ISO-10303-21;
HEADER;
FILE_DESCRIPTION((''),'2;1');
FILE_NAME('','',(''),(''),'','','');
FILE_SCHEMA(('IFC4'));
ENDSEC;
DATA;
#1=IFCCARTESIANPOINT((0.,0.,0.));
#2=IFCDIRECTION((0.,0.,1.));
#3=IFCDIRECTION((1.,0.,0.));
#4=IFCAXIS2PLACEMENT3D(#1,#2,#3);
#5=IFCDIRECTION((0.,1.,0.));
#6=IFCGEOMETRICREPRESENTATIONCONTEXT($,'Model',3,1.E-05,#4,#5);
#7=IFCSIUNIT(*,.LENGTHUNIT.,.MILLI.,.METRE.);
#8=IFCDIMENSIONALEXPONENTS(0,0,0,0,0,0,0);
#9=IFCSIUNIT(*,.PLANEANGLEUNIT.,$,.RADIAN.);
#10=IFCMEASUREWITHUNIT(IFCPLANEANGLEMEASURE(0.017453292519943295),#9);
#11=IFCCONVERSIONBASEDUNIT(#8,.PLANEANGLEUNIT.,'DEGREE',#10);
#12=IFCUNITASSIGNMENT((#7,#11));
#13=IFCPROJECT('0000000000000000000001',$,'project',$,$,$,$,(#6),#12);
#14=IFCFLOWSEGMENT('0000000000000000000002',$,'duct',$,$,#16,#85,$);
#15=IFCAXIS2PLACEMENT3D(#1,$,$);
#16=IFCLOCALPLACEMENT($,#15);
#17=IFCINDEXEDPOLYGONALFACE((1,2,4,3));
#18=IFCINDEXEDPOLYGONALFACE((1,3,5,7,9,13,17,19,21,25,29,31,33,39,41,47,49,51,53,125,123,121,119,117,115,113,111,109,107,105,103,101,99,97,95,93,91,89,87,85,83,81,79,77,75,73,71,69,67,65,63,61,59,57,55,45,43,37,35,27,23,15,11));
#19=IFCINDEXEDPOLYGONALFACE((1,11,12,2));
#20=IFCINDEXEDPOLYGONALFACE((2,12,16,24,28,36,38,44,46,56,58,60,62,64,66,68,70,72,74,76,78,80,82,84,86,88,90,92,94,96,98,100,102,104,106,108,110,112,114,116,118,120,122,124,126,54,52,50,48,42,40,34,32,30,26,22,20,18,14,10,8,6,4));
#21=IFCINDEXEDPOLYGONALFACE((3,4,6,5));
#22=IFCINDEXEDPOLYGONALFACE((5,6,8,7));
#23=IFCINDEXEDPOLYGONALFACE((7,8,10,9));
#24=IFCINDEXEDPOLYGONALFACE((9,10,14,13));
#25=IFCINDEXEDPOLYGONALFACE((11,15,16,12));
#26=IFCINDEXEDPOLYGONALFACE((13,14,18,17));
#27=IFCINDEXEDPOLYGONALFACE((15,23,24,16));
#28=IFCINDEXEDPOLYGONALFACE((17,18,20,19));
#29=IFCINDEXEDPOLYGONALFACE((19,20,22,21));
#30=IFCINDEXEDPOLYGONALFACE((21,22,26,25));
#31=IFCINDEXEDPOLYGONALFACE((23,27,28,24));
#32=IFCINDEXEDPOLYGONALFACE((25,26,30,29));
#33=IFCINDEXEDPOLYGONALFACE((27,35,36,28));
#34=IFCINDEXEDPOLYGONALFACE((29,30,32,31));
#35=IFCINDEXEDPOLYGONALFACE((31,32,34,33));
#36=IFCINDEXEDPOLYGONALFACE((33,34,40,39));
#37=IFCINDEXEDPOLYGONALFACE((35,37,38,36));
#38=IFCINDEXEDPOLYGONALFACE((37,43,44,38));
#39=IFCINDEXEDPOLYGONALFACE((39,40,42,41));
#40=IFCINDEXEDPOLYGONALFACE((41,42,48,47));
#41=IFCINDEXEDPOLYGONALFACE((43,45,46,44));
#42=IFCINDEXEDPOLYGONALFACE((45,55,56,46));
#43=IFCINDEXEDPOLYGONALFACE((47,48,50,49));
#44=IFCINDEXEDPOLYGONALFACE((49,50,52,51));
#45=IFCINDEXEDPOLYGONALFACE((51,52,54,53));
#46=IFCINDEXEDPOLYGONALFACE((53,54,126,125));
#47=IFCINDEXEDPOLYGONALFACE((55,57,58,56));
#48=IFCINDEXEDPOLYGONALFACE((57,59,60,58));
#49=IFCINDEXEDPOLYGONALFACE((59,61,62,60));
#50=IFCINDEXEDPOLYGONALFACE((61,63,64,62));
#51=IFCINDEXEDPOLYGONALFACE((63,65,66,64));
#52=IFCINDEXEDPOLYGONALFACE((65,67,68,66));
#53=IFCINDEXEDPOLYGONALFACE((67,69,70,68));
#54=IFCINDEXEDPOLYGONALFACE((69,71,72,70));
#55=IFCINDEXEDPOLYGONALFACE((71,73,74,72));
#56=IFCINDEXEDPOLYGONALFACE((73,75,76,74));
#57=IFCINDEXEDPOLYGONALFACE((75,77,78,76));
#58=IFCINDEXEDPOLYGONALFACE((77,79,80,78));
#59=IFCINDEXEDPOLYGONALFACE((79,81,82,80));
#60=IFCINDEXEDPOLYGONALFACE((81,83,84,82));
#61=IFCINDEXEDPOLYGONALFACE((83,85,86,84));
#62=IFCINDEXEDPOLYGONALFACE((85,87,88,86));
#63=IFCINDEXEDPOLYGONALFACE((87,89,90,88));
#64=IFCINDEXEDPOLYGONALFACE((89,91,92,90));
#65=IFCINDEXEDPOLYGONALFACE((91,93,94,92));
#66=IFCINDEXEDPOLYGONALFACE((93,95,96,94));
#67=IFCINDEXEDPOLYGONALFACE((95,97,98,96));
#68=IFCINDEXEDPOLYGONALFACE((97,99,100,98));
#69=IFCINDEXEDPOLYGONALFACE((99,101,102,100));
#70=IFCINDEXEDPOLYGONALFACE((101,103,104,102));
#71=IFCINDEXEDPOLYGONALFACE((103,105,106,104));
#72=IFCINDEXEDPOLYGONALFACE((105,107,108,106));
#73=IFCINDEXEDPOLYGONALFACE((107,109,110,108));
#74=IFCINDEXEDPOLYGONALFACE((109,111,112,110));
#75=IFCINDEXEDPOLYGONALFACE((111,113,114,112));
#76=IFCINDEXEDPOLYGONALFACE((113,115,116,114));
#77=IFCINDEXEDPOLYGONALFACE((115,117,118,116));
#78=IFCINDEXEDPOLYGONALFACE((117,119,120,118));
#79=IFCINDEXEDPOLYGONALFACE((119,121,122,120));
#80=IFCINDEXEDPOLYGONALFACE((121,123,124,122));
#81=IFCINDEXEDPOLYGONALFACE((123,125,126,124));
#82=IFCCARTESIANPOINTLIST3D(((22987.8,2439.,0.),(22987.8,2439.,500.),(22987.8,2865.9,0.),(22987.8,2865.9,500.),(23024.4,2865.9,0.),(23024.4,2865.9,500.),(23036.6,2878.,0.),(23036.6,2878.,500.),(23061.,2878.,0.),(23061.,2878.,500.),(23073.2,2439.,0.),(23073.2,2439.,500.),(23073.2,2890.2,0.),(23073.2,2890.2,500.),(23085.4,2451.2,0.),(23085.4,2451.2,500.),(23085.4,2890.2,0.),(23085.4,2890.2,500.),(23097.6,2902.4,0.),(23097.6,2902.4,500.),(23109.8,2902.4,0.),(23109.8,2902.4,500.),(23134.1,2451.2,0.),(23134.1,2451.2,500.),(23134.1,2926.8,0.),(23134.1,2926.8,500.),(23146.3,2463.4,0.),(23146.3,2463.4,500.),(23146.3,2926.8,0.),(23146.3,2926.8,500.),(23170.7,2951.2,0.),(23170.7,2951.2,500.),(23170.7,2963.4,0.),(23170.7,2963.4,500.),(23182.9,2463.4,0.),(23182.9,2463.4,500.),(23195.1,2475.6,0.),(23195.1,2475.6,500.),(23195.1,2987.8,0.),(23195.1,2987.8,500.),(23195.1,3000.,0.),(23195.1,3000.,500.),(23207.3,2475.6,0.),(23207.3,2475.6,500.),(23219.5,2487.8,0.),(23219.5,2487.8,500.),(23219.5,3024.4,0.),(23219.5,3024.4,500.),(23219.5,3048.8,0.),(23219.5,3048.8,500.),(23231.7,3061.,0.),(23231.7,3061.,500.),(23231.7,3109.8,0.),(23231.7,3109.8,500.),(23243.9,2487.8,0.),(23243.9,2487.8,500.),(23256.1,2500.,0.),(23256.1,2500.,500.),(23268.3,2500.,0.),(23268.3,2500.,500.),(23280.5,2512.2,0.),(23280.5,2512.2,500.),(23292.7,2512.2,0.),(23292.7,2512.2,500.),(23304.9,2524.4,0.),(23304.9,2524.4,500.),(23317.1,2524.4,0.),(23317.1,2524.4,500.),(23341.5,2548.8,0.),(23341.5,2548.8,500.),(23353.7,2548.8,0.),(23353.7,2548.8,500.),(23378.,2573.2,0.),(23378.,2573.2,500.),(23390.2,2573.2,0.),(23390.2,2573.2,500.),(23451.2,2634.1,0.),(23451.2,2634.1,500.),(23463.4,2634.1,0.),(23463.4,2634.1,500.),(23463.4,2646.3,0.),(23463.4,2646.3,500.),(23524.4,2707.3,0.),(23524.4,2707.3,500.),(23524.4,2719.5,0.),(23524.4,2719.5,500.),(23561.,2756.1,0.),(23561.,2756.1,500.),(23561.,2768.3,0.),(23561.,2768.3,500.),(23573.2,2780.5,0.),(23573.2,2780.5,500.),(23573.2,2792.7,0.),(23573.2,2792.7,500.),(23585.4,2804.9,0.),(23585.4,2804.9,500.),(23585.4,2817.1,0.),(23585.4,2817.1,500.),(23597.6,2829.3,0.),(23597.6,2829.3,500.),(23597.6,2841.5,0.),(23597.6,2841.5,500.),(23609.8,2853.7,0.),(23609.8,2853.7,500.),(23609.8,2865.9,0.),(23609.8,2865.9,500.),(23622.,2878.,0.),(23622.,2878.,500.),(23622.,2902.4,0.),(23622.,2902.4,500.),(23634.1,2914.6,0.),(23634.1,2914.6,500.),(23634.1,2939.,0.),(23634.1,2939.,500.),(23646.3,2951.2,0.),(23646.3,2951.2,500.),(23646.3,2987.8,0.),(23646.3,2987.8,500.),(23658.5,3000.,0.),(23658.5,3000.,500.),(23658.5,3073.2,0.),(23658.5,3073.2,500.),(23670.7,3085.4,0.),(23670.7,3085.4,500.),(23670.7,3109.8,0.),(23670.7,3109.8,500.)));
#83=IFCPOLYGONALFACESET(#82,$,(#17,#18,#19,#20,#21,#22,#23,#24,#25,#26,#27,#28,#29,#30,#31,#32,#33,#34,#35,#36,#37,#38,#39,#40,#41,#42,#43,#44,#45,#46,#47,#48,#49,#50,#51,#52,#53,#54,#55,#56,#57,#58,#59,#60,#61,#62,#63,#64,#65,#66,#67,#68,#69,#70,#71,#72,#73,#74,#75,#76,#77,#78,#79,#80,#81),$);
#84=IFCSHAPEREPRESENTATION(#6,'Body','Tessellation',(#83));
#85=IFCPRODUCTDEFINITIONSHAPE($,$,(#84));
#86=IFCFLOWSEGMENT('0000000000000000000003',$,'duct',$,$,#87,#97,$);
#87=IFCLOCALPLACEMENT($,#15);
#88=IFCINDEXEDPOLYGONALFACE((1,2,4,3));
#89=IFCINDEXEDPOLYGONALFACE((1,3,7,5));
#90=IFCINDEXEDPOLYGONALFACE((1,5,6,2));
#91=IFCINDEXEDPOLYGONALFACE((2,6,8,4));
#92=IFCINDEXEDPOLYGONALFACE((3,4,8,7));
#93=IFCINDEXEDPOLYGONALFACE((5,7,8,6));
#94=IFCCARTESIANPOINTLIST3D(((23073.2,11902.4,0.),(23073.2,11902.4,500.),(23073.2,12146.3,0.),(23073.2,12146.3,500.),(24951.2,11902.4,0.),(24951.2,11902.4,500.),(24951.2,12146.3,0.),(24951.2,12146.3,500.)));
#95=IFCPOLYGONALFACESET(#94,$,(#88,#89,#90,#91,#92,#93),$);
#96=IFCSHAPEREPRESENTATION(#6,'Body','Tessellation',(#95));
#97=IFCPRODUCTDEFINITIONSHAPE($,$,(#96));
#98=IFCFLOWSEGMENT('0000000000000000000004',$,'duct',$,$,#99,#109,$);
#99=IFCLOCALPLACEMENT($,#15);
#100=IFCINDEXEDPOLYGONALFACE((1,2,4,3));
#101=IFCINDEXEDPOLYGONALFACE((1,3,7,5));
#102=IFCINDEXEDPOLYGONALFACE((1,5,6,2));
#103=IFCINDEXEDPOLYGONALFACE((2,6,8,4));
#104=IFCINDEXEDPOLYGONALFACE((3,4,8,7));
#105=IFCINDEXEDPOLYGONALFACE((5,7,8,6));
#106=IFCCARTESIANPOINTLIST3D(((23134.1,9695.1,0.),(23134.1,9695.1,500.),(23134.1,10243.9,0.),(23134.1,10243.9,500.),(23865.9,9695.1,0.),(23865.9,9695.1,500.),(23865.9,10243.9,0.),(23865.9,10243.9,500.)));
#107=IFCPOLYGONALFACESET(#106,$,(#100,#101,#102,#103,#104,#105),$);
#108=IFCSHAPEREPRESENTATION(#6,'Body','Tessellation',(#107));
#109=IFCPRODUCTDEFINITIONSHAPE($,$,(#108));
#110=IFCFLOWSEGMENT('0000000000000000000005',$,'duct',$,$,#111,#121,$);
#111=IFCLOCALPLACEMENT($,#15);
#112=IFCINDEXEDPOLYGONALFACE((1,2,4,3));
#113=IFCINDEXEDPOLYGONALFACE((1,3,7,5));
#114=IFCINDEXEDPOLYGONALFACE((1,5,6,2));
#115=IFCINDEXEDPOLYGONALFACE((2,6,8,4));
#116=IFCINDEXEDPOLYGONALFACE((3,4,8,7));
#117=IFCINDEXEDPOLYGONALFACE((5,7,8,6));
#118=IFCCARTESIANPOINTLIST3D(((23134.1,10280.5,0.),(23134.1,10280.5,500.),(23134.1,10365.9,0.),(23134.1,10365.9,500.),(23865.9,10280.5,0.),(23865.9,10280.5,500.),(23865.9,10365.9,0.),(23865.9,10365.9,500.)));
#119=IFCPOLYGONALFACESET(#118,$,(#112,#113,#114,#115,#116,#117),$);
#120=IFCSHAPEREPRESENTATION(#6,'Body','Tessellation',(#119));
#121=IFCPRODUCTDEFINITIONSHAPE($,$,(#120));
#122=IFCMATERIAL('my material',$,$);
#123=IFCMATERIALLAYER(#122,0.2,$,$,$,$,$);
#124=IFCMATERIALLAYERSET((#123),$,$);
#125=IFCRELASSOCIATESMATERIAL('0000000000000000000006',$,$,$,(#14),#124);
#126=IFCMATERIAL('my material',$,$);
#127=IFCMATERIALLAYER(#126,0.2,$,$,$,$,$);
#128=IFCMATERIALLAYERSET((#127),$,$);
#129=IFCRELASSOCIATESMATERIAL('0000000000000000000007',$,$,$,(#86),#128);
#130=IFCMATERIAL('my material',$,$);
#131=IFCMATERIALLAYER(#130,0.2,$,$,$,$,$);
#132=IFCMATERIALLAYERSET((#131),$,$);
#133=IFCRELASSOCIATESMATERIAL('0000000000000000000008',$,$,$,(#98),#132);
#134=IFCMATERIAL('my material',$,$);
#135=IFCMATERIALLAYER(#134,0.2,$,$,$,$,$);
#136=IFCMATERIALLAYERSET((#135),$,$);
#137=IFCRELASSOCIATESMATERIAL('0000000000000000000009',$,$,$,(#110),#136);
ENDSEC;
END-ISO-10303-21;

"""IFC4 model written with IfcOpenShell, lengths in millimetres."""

from ifc_helpers import new_model, entity, si_unit, converted_unit, direction, origin_with_axes, place, context, project, polyline, outline, extrude, material, layer, layer_set, layer_usage, element, save


model = new_model("IFC4")

# Units and contexts
model_context = context("Model", 3, precision=1e-05, world=origin_with_axes(), true_north=direction((0.0, 1.0, 0.0)))
ifc_project = project(units=[si_unit("LENGTHUNIT", "METRE", prefix="MILLI"), converted_unit("PLANEANGLEUNIT", "DEGREE", entity("IfcPlaneAngleMeasure", 0.017453292519943295), si_unit("PLANEANGLEUNIT", "RADIAN"), dimensions=[0, 0, 0, 0, 0, 0, 0])], contexts=[model_context])

# Flow segments
ifc_material_1 = material(Name="my material")
ifc_layer_1 = layer(ifc_material_1, 0.2)
ifc_layer_set_1 = layer_set([ifc_layer_1])
ifc_layer_usage_1 = layer_usage(ifc_layer_set_1, "AXIS2", "POSITIVE", -0.1)
flow_segment_1_placement = place(None, origin_with_axes())
element("IfcFlowSegment", 1, at=flow_segment_1_placement, material=ifc_layer_usage_1, Name="duct", context=model_context, shape_type="SweptSolid", body=[
    extrude(outline(polyline([(22987.8, 2439.0), (23073.2, 2439.0), (23085.4, 2451.2), (23134.1, 2451.2), (23146.3, 2463.4), (23182.9, 2463.4), (23195.1, 2475.6), (23207.3, 2475.6), (23219.5, 2487.8), (23243.9, 2487.8), (23256.1, 2500.0), (23268.3, 2500.0), (23280.5, 2512.2), (23292.7, 2512.2), (23304.9, 2524.4), (23317.1, 2524.4), (23341.5, 2548.8), (23353.7, 2548.8), (23378.0, 2573.2), (23390.2, 2573.2), (23451.2, 2634.1), (23463.4, 2634.1), (23463.4, 2646.3), (23524.4, 2707.3), (23524.4, 2719.5), (23561.0, 2756.1), (23561.0, 2768.3), (23573.2, 2780.5), (23573.2, 2792.7), (23585.4, 2804.9), (23585.4, 2817.1), (23597.6, 2829.3), (23597.6, 2841.5), (23609.8, 2853.7), (23609.8, 2865.9), (23622.0, 2878.0), (23622.0, 2902.4), (23634.1, 2914.6), (23634.1, 2939.0), (23646.3, 2951.2), (23646.3, 2987.8), (23658.5, 3000.0), (23658.5, 3073.2), (23670.7, 3085.4), (23670.7, 3109.8), (23231.7, 3109.8), (23231.7, 3061.0), (23219.5, 3048.8), (23219.5, 3024.4), (23195.1, 3000.0), (23195.1, 2987.8), (23170.7, 2963.4), (23170.7, 2951.2), (23146.3, 2926.8), (23134.1, 2926.8), (23109.8, 2902.4), (23097.6, 2902.4), (23085.4, 2890.2), (23073.2, 2890.2), (23061.0, 2878.0), (23036.6, 2878.0), (23024.4, 2865.9), (22987.8, 2865.9), (22987.8, 2439.0)])), origin_with_axes(), (0.0, 0.0, 1.0), 500.0),
])
ifc_material_2 = material(Name="my material")
ifc_layer_2 = layer(ifc_material_2, 0.2)
ifc_layer_set_2 = layer_set([ifc_layer_2])
ifc_layer_usage_2 = layer_usage(ifc_layer_set_2, "AXIS2", "POSITIVE", -0.1)
flow_segment_2_placement = place(None, origin_with_axes())
element("IfcFlowSegment", 2, at=flow_segment_2_placement, material=ifc_layer_usage_2, Name="duct", context=model_context, shape_type="SweptSolid", body=[
    extrude(outline(polyline([(23073.2, 11902.4), (24951.2, 11902.4), (24951.2, 12146.3), (23073.2, 12146.3), (23073.2, 11902.4)])), origin_with_axes(), (0.0, 0.0, 1.0), 500.0),
])
ifc_material_3 = material(Name="my material")
ifc_layer_3 = layer(ifc_material_3, 0.2)
ifc_layer_set_3 = layer_set([ifc_layer_3])
ifc_layer_usage_3 = layer_usage(ifc_layer_set_3, "AXIS2", "POSITIVE", -0.1)
flow_segment_3_placement = place(None, origin_with_axes())
element("IfcFlowSegment", 3, at=flow_segment_3_placement, material=ifc_layer_usage_3, Name="duct", context=model_context, shape_type="SweptSolid", body=[
    extrude(outline(polyline([(23134.1, 9695.1), (23865.9, 9695.1), (23865.9, 10243.9), (23134.1, 10243.9), (23134.1, 9695.1)])), origin_with_axes(), (0.0, 0.0, 1.0), 500.0),
])
ifc_material_4 = material(Name="my material")
ifc_layer_4 = layer(ifc_material_4, 0.2)
ifc_layer_set_4 = layer_set([ifc_layer_4])
ifc_layer_usage_4 = layer_usage(ifc_layer_set_4, "AXIS2", "POSITIVE", -0.1)
flow_segment_4_placement = place(None, origin_with_axes())
element("IfcFlowSegment", 4, at=flow_segment_4_placement, material=ifc_layer_usage_4, Name="duct", context=model_context, shape_type="SweptSolid", body=[
    extrude(outline(polyline([(23134.1, 10280.5), (23865.9, 10280.5), (23865.9, 10365.9), (23134.1, 10365.9), (23134.1, 10280.5)])), origin_with_axes(), (0.0, 0.0, 1.0), 500.0),
])

save(model, "model.ifc")
